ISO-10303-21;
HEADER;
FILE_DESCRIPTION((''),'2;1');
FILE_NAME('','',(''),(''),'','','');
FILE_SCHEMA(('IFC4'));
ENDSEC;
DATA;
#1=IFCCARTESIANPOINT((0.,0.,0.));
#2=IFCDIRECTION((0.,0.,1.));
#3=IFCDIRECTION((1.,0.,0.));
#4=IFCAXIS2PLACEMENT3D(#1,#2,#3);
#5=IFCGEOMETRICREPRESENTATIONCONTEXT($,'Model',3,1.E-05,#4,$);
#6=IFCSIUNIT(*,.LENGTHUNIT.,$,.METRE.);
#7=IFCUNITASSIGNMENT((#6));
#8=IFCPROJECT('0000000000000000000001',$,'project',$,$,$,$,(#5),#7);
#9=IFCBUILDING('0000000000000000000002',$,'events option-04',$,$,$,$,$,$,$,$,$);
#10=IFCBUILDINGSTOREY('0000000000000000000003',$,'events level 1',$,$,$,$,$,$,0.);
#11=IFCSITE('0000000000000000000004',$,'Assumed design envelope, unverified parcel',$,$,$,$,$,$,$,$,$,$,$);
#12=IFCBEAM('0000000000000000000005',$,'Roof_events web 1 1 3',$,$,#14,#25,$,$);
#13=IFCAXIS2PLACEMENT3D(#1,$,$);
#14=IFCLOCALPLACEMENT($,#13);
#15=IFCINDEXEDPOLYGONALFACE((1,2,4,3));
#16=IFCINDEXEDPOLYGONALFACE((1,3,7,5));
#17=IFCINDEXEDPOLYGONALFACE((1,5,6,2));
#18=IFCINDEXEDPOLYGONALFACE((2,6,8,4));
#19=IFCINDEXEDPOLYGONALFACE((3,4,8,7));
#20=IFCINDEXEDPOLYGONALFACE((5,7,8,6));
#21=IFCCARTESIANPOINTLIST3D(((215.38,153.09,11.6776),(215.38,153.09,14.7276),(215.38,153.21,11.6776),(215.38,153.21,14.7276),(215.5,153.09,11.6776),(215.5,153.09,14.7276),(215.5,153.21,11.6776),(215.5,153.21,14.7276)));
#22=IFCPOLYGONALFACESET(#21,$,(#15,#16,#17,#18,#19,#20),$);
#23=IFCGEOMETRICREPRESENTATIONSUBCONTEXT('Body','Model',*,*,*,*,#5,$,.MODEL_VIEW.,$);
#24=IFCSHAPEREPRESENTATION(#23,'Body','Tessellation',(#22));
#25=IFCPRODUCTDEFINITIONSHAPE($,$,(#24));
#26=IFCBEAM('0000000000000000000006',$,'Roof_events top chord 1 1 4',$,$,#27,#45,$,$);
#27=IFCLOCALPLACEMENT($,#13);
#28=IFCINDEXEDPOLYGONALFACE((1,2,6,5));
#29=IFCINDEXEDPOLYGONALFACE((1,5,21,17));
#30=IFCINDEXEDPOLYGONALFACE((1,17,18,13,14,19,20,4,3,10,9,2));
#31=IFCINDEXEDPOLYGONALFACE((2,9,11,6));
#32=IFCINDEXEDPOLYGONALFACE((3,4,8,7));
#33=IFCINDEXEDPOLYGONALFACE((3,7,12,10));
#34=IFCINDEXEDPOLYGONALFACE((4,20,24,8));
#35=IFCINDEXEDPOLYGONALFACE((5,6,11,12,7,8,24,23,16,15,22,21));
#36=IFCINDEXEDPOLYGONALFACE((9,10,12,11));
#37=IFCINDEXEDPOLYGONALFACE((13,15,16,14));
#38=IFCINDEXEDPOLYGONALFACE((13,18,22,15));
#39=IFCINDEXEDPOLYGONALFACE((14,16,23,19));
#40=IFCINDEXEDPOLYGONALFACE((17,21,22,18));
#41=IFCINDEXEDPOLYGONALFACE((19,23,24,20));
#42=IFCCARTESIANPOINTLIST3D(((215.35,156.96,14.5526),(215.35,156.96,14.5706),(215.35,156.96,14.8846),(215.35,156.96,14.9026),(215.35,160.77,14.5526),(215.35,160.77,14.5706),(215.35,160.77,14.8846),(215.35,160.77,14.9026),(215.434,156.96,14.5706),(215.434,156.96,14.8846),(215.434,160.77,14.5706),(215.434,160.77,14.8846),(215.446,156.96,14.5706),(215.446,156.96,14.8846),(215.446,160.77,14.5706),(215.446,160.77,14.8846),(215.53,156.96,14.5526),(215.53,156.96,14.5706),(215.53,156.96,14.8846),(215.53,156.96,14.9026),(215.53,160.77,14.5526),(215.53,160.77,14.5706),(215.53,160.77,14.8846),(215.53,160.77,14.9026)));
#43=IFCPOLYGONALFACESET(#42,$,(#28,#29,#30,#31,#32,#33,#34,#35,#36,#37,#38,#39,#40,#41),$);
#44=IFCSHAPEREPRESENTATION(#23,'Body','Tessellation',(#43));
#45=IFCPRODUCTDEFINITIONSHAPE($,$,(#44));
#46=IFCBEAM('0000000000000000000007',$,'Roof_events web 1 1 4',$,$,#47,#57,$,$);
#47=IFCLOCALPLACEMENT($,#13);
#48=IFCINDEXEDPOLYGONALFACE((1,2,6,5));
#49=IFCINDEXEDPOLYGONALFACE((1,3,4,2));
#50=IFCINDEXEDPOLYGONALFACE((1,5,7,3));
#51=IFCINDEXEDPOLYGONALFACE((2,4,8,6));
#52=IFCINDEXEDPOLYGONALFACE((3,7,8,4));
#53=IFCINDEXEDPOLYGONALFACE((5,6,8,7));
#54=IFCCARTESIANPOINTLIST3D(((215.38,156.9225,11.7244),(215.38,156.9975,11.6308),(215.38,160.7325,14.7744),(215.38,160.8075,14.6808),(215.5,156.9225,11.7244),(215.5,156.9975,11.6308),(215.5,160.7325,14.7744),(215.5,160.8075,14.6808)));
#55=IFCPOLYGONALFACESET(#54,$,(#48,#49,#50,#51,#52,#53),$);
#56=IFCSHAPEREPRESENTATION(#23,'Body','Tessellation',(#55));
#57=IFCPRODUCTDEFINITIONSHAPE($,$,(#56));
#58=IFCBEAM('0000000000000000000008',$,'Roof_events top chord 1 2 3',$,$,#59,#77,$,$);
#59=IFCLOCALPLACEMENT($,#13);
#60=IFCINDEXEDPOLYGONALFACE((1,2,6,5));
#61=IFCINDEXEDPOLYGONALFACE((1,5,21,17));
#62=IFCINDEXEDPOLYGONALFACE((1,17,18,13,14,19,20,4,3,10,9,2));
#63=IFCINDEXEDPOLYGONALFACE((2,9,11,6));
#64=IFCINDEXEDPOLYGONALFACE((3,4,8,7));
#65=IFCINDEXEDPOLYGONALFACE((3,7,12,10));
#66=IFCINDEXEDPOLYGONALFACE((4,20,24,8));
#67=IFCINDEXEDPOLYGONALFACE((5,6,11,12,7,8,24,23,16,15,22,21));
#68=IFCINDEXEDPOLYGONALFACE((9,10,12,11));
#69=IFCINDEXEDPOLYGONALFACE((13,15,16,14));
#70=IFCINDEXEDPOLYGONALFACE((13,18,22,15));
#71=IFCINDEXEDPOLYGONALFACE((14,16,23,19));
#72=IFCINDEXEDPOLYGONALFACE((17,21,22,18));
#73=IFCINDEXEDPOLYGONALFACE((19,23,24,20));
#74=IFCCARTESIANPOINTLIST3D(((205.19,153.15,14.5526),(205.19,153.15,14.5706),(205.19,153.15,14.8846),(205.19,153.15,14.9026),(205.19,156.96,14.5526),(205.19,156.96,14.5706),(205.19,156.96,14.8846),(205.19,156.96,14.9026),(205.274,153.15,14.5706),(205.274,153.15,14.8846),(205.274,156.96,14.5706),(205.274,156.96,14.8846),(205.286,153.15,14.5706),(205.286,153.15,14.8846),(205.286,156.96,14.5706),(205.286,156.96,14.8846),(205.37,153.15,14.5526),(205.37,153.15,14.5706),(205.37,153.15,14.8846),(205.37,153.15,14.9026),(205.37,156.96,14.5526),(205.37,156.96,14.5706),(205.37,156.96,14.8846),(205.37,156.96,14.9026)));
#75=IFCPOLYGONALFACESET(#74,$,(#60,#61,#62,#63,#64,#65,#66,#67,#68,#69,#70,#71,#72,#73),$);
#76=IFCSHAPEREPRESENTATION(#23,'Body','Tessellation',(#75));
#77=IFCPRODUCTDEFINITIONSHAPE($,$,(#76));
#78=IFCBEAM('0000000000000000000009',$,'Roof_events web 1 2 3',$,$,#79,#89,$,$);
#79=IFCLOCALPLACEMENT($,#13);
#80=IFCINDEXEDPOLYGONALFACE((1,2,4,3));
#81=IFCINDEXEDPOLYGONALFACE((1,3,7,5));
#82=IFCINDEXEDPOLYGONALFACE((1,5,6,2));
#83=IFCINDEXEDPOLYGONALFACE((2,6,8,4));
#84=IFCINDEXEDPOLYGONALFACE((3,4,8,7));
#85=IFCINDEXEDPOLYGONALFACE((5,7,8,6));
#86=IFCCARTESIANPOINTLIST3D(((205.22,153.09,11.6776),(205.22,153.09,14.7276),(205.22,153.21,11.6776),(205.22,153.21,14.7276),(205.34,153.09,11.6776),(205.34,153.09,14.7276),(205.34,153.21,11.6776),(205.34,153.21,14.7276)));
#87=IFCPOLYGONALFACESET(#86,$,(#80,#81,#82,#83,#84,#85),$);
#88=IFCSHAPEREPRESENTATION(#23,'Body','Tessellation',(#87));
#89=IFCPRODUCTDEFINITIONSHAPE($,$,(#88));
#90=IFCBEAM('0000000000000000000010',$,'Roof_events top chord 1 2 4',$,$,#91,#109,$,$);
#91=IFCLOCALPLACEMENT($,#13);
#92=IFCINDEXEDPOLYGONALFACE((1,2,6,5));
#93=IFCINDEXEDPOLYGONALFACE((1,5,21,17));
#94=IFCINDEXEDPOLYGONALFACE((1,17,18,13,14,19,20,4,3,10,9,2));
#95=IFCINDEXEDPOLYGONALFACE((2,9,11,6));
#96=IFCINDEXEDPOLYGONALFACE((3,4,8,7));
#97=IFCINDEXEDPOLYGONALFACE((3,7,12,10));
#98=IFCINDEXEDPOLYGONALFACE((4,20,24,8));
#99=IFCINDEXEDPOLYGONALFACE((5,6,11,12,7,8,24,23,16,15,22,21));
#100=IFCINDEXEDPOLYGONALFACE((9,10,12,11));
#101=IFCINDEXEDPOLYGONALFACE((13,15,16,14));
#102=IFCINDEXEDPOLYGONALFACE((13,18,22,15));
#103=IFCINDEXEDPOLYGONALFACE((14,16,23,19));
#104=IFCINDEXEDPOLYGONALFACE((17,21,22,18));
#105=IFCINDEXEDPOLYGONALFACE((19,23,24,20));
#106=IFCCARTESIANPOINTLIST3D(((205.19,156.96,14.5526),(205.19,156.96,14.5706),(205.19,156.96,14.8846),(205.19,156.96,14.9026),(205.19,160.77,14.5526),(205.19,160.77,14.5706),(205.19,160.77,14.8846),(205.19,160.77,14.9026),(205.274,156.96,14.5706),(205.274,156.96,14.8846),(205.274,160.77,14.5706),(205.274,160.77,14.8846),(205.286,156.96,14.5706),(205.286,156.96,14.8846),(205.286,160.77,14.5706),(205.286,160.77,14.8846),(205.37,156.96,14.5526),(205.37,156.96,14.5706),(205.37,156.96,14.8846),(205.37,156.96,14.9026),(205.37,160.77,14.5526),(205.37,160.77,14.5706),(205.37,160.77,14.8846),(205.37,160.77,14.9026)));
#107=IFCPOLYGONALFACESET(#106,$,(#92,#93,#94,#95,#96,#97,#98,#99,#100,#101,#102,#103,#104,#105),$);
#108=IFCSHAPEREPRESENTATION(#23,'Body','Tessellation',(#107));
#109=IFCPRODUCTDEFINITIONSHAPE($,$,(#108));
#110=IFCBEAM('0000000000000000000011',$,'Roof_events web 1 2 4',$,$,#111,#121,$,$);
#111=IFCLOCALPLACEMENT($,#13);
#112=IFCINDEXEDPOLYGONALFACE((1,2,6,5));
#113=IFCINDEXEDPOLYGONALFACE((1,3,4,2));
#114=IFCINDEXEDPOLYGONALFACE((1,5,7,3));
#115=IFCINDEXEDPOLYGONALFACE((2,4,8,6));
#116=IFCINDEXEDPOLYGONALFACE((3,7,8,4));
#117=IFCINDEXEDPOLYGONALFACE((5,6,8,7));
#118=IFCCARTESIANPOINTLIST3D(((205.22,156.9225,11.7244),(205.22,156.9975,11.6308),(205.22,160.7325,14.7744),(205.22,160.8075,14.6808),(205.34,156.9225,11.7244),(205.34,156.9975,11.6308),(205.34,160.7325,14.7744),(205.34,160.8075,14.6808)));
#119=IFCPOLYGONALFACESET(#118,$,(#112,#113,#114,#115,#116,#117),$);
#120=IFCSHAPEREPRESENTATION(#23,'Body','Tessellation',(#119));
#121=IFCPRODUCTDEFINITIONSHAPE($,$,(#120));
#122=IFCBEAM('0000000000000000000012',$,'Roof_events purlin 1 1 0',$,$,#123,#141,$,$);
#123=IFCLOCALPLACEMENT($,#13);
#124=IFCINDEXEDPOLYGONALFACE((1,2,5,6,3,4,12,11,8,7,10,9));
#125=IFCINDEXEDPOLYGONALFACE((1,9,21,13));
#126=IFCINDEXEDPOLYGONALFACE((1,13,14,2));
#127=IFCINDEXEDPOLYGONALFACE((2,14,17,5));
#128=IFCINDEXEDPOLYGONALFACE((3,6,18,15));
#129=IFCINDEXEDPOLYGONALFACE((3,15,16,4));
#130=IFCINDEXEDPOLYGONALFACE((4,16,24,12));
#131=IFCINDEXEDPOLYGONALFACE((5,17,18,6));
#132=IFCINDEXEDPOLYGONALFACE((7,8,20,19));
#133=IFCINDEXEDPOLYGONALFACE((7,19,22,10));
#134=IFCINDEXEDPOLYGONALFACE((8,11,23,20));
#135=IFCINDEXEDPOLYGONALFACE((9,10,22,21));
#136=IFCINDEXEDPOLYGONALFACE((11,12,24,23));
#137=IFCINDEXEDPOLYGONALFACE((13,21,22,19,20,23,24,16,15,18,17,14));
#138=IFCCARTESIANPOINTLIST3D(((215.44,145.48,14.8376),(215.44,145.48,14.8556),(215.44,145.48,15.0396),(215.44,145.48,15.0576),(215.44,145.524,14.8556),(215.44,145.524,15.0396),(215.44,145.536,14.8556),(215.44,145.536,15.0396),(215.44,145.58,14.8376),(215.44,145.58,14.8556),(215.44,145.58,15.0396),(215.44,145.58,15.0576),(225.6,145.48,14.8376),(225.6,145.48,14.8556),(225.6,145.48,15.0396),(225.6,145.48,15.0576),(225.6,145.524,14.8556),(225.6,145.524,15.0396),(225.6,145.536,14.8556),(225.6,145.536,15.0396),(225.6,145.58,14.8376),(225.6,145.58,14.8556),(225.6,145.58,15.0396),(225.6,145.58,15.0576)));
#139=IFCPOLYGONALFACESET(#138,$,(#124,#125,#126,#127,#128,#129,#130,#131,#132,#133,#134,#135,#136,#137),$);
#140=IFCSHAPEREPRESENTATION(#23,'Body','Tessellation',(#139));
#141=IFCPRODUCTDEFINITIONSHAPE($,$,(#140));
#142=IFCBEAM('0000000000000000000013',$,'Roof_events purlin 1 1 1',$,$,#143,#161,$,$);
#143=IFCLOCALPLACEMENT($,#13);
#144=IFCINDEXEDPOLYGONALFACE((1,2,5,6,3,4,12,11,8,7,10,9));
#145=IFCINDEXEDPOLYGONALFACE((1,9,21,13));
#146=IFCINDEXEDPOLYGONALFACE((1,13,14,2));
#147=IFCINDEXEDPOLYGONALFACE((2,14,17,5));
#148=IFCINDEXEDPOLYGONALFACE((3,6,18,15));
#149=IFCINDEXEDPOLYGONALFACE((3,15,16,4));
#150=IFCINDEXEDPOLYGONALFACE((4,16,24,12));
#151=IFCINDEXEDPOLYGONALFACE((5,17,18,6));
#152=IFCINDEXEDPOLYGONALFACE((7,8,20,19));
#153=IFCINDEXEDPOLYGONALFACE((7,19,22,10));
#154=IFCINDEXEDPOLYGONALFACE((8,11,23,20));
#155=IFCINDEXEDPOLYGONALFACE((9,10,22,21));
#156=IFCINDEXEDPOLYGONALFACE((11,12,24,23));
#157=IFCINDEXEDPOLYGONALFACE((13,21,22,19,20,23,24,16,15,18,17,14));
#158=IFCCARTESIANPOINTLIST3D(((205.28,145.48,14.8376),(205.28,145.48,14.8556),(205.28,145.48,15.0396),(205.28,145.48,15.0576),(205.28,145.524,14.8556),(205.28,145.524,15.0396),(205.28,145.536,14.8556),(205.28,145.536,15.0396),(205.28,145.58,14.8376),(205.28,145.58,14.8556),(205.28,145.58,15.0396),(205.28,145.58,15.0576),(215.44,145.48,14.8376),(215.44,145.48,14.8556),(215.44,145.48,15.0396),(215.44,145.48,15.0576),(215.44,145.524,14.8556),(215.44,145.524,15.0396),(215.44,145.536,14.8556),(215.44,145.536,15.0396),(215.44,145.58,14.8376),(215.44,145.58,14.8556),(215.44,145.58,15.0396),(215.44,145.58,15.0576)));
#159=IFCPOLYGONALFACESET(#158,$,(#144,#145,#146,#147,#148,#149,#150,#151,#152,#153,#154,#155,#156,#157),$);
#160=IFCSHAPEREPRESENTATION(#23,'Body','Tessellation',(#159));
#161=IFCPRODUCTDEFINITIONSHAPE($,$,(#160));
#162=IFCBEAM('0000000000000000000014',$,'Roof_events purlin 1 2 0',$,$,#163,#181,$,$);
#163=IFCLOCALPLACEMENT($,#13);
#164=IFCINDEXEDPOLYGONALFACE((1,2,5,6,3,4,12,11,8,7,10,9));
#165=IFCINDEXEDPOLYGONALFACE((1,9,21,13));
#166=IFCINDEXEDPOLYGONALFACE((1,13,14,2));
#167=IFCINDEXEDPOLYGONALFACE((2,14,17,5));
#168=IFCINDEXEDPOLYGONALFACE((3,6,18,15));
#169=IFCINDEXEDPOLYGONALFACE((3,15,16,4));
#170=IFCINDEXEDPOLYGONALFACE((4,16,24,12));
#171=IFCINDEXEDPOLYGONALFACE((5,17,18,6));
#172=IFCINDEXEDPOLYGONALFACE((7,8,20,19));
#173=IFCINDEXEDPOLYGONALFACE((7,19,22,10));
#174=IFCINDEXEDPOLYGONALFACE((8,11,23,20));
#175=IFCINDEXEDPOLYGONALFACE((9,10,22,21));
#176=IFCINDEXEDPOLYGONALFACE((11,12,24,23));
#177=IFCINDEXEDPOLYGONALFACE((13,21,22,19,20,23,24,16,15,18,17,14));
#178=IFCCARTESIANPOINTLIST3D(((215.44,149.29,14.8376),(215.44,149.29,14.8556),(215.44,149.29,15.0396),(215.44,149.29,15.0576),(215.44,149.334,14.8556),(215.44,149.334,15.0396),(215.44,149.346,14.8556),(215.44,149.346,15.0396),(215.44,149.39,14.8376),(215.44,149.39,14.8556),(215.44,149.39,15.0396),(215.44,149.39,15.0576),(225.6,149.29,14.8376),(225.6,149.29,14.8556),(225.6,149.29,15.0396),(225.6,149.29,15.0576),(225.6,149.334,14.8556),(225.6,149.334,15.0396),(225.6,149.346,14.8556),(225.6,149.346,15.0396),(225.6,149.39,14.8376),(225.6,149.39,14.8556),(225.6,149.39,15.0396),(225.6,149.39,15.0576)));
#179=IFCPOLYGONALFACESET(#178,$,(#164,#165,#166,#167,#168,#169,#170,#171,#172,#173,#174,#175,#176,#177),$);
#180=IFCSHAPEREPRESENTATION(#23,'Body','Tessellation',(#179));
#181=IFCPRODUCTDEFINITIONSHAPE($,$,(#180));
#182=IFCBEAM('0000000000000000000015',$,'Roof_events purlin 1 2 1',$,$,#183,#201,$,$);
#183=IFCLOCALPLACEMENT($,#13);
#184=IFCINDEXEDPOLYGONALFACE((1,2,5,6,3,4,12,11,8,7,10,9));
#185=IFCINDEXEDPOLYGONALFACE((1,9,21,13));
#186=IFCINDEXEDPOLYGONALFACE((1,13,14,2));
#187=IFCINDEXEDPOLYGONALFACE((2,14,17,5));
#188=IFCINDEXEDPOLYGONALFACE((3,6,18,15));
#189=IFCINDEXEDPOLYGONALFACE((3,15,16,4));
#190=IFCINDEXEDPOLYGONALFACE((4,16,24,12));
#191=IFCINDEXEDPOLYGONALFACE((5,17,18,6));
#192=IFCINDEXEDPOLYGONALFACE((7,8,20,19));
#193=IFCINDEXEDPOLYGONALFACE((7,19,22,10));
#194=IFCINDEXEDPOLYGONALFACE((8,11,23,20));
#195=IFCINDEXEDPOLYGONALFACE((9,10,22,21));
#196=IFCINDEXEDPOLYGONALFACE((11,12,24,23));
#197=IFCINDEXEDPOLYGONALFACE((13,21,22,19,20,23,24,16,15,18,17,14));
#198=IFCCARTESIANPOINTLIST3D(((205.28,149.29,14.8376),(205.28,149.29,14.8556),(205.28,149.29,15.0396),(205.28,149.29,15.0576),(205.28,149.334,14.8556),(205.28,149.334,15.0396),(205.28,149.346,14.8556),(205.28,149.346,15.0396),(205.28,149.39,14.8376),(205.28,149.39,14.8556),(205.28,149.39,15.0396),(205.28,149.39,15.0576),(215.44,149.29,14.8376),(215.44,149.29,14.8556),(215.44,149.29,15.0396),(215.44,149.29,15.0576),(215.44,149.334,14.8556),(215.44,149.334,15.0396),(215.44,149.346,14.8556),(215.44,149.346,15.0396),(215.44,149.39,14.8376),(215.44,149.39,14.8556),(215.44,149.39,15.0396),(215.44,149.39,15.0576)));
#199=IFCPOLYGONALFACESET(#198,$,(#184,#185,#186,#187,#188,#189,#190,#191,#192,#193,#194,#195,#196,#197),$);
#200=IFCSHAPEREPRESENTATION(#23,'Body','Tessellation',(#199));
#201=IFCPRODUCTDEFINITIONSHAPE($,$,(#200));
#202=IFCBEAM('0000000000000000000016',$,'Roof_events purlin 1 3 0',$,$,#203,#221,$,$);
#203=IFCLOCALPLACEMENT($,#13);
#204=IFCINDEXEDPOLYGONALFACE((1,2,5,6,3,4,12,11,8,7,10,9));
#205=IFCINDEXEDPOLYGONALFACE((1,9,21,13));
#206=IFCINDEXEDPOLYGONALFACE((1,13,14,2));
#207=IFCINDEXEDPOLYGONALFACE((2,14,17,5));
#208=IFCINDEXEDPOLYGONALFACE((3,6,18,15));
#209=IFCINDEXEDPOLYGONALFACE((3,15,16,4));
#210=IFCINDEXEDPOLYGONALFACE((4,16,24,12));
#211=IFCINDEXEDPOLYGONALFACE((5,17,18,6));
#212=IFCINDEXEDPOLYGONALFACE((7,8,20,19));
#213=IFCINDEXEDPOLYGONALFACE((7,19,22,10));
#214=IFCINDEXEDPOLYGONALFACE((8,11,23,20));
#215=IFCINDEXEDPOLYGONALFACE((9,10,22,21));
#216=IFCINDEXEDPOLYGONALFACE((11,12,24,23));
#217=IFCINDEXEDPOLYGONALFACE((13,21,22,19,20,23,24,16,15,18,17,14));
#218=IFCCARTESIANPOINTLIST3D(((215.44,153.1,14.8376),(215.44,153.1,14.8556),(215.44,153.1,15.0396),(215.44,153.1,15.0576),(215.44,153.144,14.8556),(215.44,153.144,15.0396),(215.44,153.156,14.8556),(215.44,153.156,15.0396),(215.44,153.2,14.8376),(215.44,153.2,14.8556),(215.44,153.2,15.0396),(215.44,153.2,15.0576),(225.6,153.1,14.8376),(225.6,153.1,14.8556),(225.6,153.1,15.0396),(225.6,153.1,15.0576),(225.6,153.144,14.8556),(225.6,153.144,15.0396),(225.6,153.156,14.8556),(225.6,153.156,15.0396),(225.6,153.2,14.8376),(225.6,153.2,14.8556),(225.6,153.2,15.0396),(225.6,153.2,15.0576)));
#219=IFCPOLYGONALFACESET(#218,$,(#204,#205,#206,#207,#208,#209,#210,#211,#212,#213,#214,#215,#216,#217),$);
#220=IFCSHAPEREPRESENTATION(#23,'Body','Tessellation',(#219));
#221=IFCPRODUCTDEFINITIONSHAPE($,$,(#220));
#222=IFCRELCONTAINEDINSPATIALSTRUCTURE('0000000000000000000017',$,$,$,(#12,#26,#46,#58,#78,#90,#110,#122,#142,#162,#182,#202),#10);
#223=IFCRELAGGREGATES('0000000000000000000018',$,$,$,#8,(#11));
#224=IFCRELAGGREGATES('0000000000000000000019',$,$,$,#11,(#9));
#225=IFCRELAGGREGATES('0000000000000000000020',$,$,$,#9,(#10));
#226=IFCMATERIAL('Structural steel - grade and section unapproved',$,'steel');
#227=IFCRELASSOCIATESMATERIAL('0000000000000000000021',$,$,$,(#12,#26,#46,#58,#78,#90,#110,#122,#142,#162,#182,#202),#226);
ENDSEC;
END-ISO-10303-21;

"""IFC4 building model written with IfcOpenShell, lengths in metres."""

from ifc_helpers import new_model, si_unit, frame, origin_with_axes, place, context, subcontext, project, spatial, rectangle, i_section, extrude, material, element, save


model = new_model("IFC4")

# Units and contexts
model_context = context("Model", 3, precision=1e-05, world=origin_with_axes())
body_context = subcontext(model_context, "Body", "Model", "MODEL_VIEW")
ifc_project = project(units=[si_unit("LENGTHUNIT", "METRE")], contexts=[model_context])

# Site, building, storey
site = spatial("IfcSite", under=ifc_project, Name="Assumed design envelope, unverified parcel")
building = spatial("IfcBuilding", under=site, Name="events option-04")
storey = spatial("IfcBuildingStorey", under=building, Name="events level 1", Elevation=0.0)

# Beams
ifc_material = material(Name="Structural steel - grade and section unapproved", Category="steel")
beam_1_placement = place(None, frame((215.44, 153.15, 11.6776), z_axis=(0.0, 0.0, 1.0), x_axis=(-1.0, 0.0, 0.0)))
element("IfcBeam", 1, at=beam_1_placement, inside=storey, material=ifc_material, Name="Roof_events web 1 1 3", context=body_context, shape_type="SweptSolid", body=[
    extrude(rectangle(XDim=0.12, YDim=0.12), origin_with_axes(), (0.0, 0.0, 1.0), 3.05),
])
beam_2_placement = place(None, frame((215.44, 156.96, 14.7276), z_axis=(0.0, 1.0, 0.0), x_axis=(-1.0, 0.0, 0.0)))
element("IfcBeam", 2, at=beam_2_placement, inside=storey, material=ifc_material, Name="Roof_events top chord 1 1 4", context=body_context, shape_type="SweptSolid", body=[
    extrude(i_section(OverallWidth=0.18, OverallDepth=0.35, WebThickness=0.012, FlangeThickness=0.018, FilletRadius=0.0), origin_with_axes(), (0.0, 0.0, 1.0), 3.81),
])
beam_3_placement = place(None, frame((215.44, 156.96, 11.6776), z_axis=(0.0, 0.780669, 0.624945), x_axis=(-1.0, 0.0, 0.0)))
element("IfcBeam", 3, at=beam_3_placement, inside=storey, material=ifc_material, Name="Roof_events web 1 1 4", context=body_context, shape_type="SweptSolid", body=[
    extrude(rectangle(XDim=0.12, YDim=0.12), origin_with_axes(), (0.0, 0.0, 1.0), 4.8804),
])
beam_4_placement = place(None, frame((205.28, 153.15, 14.7276), z_axis=(0.0, 1.0, 0.0), x_axis=(-1.0, 0.0, 0.0)))
element("IfcBeam", 4, at=beam_4_placement, inside=storey, material=ifc_material, Name="Roof_events top chord 1 2 3", context=body_context, shape_type="SweptSolid", body=[
    extrude(i_section(OverallWidth=0.18, OverallDepth=0.35, WebThickness=0.012, FlangeThickness=0.018, FilletRadius=0.0), origin_with_axes(), (0.0, 0.0, 1.0), 3.81),
])
beam_5_placement = place(None, frame((205.28, 153.15, 11.6776), z_axis=(0.0, 0.0, 1.0), x_axis=(-1.0, 0.0, 0.0)))
element("IfcBeam", 5, at=beam_5_placement, inside=storey, material=ifc_material, Name="Roof_events web 1 2 3", context=body_context, shape_type="SweptSolid", body=[
    extrude(rectangle(XDim=0.12, YDim=0.12), origin_with_axes(), (0.0, 0.0, 1.0), 3.05),
])
beam_6_placement = place(None, frame((205.28, 156.96, 14.7276), z_axis=(0.0, 1.0, 0.0), x_axis=(-1.0, 0.0, 0.0)))
element("IfcBeam", 6, at=beam_6_placement, inside=storey, material=ifc_material, Name="Roof_events top chord 1 2 4", context=body_context, shape_type="SweptSolid", body=[
    extrude(i_section(OverallWidth=0.18, OverallDepth=0.35, WebThickness=0.012, FlangeThickness=0.018, FilletRadius=0.0), origin_with_axes(), (0.0, 0.0, 1.0), 3.81),
])
beam_7_placement = place(None, frame((205.28, 156.96, 11.6776), z_axis=(0.0, 0.780669, 0.624945), x_axis=(-1.0, 0.0, 0.0)))
element("IfcBeam", 7, at=beam_7_placement, inside=storey, material=ifc_material, Name="Roof_events web 1 2 4", context=body_context, shape_type="SweptSolid", body=[
    extrude(rectangle(XDim=0.12, YDim=0.12), origin_with_axes(), (0.0, 0.0, 1.0), 4.8804),
])
for number, where, z_axis, x_axis, name in (
    (8, (225.6, 145.53, 14.9476), (-1.0, 0.0, 0.0), (0.0, -1.0, 0.0), "Roof_events purlin 1 1 0"),
    (9, (215.44, 145.53, 14.9476), (-1.0, 0.0, 0.0), (0.0, -1.0, 0.0), "Roof_events purlin 1 1 1"),
    (10, (225.6, 149.34, 14.9476), (-1.0, 0.0, 0.0), (0.0, -1.0, 0.0), "Roof_events purlin 1 2 0"),
    (11, (215.44, 149.34, 14.9476), (-1.0, 0.0, 0.0), (0.0, -1.0, 0.0), "Roof_events purlin 1 2 1"),
    (12, (225.6, 153.15, 14.9476), (-1.0, 0.0, 0.0), (0.0, -1.0, 0.0), "Roof_events purlin 1 3 0"),
):
    element("IfcBeam", number, at=place(None, frame(where, z_axis=z_axis, x_axis=x_axis)), inside=storey, material=ifc_material, Name=name, context=body_context, shape_type="SweptSolid", body=[
        extrude(i_section(OverallWidth=0.1, OverallDepth=0.22, WebThickness=0.012, FlangeThickness=0.018, FilletRadius=0.0), origin_with_axes(), (0.0, 0.0, 1.0), 10.16),
    ])

save(model, "model.ifc")
